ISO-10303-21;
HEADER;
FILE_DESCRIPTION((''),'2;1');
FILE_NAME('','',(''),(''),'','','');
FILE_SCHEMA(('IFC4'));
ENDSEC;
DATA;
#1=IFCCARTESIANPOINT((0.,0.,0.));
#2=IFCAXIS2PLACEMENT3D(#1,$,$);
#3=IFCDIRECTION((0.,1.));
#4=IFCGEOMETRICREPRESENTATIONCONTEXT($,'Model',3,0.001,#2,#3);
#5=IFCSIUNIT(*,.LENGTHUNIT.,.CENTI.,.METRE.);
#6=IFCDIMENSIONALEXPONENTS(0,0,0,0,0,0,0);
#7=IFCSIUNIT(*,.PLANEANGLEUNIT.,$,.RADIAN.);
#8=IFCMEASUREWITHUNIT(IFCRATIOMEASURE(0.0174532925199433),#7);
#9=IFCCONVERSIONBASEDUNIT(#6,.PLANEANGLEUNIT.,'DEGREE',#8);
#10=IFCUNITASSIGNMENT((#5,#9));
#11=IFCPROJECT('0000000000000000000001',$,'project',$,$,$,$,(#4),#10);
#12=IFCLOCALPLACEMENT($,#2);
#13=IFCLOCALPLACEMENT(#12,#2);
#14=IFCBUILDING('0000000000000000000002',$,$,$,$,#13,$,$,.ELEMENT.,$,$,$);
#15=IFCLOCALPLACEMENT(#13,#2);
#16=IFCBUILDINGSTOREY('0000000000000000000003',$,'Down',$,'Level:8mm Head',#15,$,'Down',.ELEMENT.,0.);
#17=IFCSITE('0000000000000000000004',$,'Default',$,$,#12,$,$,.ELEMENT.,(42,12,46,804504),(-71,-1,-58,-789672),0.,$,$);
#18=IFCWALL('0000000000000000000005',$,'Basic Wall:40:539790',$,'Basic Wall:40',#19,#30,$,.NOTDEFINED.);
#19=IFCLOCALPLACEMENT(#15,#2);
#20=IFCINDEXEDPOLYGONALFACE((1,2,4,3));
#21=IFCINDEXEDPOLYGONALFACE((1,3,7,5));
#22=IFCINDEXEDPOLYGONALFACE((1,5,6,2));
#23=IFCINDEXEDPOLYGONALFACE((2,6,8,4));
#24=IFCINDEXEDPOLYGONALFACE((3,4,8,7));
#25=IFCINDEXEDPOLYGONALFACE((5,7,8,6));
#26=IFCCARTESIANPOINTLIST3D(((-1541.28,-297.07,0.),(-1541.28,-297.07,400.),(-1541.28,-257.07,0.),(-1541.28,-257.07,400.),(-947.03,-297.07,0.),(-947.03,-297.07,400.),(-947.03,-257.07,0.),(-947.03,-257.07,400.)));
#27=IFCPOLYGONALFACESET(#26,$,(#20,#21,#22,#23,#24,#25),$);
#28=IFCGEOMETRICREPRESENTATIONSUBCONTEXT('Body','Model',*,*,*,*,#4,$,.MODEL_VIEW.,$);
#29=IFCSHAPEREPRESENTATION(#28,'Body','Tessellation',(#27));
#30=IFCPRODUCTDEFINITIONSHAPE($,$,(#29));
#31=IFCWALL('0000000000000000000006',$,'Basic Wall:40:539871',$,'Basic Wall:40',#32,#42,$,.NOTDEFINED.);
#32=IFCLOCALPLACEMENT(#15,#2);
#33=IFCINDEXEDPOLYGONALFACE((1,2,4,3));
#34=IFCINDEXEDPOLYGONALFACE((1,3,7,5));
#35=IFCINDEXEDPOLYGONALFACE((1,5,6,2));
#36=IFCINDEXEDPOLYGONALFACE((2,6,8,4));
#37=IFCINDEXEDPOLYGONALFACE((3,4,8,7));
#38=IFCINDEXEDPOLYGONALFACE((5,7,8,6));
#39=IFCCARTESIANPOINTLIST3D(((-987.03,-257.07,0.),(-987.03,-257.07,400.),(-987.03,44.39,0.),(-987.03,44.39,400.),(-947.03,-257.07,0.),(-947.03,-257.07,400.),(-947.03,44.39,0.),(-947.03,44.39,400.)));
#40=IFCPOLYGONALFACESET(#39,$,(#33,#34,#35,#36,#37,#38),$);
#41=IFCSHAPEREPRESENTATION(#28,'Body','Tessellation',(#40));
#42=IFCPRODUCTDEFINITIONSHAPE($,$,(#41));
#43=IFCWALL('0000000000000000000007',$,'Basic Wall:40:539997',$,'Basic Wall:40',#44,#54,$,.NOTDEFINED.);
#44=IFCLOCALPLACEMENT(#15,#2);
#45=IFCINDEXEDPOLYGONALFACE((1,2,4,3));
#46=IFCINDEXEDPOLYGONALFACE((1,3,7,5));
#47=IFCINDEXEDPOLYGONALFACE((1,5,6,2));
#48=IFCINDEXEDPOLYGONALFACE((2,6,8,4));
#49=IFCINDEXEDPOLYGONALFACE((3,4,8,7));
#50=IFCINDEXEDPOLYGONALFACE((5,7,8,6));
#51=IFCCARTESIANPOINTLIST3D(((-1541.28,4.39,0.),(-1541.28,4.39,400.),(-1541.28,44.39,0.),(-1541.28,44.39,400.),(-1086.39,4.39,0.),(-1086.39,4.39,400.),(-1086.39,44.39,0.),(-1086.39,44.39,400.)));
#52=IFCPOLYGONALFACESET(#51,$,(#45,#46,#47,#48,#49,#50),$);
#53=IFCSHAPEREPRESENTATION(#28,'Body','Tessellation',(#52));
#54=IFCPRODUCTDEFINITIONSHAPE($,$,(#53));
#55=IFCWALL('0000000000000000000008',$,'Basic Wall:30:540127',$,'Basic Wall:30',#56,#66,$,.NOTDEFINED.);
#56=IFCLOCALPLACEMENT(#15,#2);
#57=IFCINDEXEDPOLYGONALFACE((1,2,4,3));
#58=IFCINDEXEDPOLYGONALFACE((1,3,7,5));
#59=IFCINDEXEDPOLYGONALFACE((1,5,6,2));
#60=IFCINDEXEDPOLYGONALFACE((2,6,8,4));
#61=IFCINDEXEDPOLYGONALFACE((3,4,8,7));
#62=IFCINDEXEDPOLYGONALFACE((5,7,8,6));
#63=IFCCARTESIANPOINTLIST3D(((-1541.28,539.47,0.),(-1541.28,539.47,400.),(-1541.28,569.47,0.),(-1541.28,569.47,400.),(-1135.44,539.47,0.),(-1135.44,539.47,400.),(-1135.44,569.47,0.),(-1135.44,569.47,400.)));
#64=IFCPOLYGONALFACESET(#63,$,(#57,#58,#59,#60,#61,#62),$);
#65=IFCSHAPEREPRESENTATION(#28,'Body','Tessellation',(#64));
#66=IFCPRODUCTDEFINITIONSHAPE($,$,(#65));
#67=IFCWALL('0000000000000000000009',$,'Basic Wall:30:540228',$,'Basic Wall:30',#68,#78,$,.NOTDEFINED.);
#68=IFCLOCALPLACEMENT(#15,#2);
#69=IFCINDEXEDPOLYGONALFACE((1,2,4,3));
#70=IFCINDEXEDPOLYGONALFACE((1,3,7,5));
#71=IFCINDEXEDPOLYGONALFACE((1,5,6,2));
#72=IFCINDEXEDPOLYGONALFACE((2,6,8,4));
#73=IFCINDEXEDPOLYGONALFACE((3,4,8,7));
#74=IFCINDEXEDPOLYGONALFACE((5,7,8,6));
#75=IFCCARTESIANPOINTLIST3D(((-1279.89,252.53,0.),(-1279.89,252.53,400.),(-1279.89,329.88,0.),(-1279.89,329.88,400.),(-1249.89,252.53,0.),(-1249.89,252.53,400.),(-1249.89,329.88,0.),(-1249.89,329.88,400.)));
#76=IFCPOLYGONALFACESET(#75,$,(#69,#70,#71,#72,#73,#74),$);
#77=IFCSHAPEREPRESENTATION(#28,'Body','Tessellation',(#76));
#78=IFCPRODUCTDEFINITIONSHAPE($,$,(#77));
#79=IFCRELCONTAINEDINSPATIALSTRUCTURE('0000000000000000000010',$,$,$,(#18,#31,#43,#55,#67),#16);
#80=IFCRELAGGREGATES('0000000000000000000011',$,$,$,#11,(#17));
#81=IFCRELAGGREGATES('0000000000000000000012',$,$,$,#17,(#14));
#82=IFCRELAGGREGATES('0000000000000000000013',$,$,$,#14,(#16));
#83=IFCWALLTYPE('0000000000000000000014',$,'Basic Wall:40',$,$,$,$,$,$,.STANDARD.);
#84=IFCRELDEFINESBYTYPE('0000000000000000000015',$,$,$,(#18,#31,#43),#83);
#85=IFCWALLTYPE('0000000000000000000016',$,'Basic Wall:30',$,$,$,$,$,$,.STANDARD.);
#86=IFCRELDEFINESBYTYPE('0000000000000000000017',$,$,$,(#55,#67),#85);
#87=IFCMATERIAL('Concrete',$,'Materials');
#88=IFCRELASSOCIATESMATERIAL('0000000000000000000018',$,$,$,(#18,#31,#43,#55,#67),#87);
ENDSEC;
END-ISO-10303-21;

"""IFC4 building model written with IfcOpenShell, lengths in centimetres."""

from ifc_helpers import new_model, entity, si_unit, converted_unit, direction, frame, origin, place, context, subcontext, project, spatial, indexed_curve, outline, extrude, material, type_object, element, save


model = new_model("IFC4")

# Units and contexts
model_context = context("Model", 3, precision=0.001, world=origin(), true_north=direction((0.0, 1.0)))
body_context = subcontext(model_context, "Body", "Model", "MODEL_VIEW")
ifc_project = project(units=[si_unit("LENGTHUNIT", "METRE", prefix="CENTI"), converted_unit("PLANEANGLEUNIT", "DEGREE", entity("IfcRatioMeasure", 0.0174532925199433), si_unit("PLANEANGLEUNIT", "RADIAN"), dimensions=[0, 0, 0, 0, 0, 0, 0])], contexts=[model_context])

# Site, building, storey
site_placement = place(None, origin())
site = spatial("IfcSite", under=ifc_project, at=site_placement, Name="Default", CompositionType="ELEMENT", RefLatitude=(42, 12, 46, 804504), RefLongitude=(-71, -1, -58, -789672), RefElevation=0.0)
building_placement = place(site_placement, origin())
building = spatial("IfcBuilding", under=site, at=building_placement, CompositionType="ELEMENT")
storey_placement = place(building_placement, origin())
storey = spatial("IfcBuildingStorey", under=building, at=storey_placement, Name="Down", ObjectType="Level:8mm Head", LongName="Down", CompositionType="ELEMENT", Elevation=0.0)

# Shared definitions
ifc_material = material(Name="Concrete", Category="Materials")

# Walls
wall_type_1 = type_object("IfcWallType", Name="Basic Wall:40", PredefinedType="STANDARD")
wall_1_placement = place(storey_placement, frame((-1541.28, -277.07, 0.0)))
element("IfcWall", 1, at=wall_1_placement, inside=storey, type_object=wall_type_1, material=ifc_material, Name="Basic Wall:40:539790", ObjectType="Basic Wall:40", PredefinedType="NOTDEFINED", context=body_context, shape_type="SweptSolid", body=[
    extrude(outline(indexed_curve([(594.25, 20.0), (0.0, 20.0), (0.0, -20.0), (594.25, -20.0), (594.25, 20.0)], self_intersect=False)), origin(), (0.0, 0.0, 1.0), 400.0),
])
wall_2_placement = place(storey_placement, frame((-967.03, -257.07, 0.0), z_axis=(0.0, 0.0, 1.0), x_axis=(0.0, 1.0, 0.0)))
element("IfcWall", 2, at=wall_2_placement, inside=storey, type_object=wall_type_1, material=ifc_material, Name="Basic Wall:40:539871", ObjectType="Basic Wall:40", PredefinedType="NOTDEFINED", context=body_context, shape_type="SweptSolid", body=[
    extrude(outline(indexed_curve([(301.46, 20.0), (0.0, 20.0), (0.0, -20.0), (301.46, -20.0), (301.46, 20.0)], self_intersect=False)), origin(), (0.0, 0.0, 1.0), 400.0),
])
wall_3_placement = place(storey_placement, frame((-1086.39, 24.39, 0.0), z_axis=(0.0, 0.0, 1.0), x_axis=(-1.0, 0.0, 0.0)))
element("IfcWall", 3, at=wall_3_placement, inside=storey, type_object=wall_type_1, material=ifc_material, Name="Basic Wall:40:539997", ObjectType="Basic Wall:40", PredefinedType="NOTDEFINED", context=body_context, shape_type="SweptSolid", body=[
    extrude(outline(indexed_curve([(454.89, 20.0), (0.0, 20.0), (0.0, -20.0), (454.89, -20.0), (454.89, 20.0)], self_intersect=False)), origin(), (0.0, 0.0, 1.0), 400.0),
])
wall_type_2 = type_object("IfcWallType", Name="Basic Wall:30", PredefinedType="STANDARD")
wall_4_placement = place(storey_placement, frame((-1541.28, 554.47, 0.0)))
element("IfcWall", 4, at=wall_4_placement, inside=storey, type_object=wall_type_2, material=ifc_material, Name="Basic Wall:30:540127", ObjectType="Basic Wall:30", PredefinedType="NOTDEFINED", context=body_context, shape_type="SweptSolid", body=[
    extrude(outline(indexed_curve([(405.84, 15.0), (0.0, 15.0), (0.0, -15.0), (405.84, -15.0), (405.84, 15.0)], self_intersect=False)), origin(), (0.0, 0.0, 1.0), 400.0),
])
wall_5_placement = place(storey_placement, frame((-1264.89, 329.88, 0.0), z_axis=(0.0, 0.0, 1.0), x_axis=(0.0, -1.0, 0.0)))
element("IfcWall", 5, at=wall_5_placement, inside=storey, type_object=wall_type_2, material=ifc_material, Name="Basic Wall:30:540228", ObjectType="Basic Wall:30", PredefinedType="NOTDEFINED", context=body_context, shape_type="SweptSolid", body=[
    extrude(outline(indexed_curve([(77.35, 15.0), (0.0, 15.0), (0.0, -15.0), (77.35, -15.0), (77.35, 15.0)], self_intersect=False)), origin(), (0.0, 0.0, 1.0), 400.0),
])

save(model, "model.ifc")
